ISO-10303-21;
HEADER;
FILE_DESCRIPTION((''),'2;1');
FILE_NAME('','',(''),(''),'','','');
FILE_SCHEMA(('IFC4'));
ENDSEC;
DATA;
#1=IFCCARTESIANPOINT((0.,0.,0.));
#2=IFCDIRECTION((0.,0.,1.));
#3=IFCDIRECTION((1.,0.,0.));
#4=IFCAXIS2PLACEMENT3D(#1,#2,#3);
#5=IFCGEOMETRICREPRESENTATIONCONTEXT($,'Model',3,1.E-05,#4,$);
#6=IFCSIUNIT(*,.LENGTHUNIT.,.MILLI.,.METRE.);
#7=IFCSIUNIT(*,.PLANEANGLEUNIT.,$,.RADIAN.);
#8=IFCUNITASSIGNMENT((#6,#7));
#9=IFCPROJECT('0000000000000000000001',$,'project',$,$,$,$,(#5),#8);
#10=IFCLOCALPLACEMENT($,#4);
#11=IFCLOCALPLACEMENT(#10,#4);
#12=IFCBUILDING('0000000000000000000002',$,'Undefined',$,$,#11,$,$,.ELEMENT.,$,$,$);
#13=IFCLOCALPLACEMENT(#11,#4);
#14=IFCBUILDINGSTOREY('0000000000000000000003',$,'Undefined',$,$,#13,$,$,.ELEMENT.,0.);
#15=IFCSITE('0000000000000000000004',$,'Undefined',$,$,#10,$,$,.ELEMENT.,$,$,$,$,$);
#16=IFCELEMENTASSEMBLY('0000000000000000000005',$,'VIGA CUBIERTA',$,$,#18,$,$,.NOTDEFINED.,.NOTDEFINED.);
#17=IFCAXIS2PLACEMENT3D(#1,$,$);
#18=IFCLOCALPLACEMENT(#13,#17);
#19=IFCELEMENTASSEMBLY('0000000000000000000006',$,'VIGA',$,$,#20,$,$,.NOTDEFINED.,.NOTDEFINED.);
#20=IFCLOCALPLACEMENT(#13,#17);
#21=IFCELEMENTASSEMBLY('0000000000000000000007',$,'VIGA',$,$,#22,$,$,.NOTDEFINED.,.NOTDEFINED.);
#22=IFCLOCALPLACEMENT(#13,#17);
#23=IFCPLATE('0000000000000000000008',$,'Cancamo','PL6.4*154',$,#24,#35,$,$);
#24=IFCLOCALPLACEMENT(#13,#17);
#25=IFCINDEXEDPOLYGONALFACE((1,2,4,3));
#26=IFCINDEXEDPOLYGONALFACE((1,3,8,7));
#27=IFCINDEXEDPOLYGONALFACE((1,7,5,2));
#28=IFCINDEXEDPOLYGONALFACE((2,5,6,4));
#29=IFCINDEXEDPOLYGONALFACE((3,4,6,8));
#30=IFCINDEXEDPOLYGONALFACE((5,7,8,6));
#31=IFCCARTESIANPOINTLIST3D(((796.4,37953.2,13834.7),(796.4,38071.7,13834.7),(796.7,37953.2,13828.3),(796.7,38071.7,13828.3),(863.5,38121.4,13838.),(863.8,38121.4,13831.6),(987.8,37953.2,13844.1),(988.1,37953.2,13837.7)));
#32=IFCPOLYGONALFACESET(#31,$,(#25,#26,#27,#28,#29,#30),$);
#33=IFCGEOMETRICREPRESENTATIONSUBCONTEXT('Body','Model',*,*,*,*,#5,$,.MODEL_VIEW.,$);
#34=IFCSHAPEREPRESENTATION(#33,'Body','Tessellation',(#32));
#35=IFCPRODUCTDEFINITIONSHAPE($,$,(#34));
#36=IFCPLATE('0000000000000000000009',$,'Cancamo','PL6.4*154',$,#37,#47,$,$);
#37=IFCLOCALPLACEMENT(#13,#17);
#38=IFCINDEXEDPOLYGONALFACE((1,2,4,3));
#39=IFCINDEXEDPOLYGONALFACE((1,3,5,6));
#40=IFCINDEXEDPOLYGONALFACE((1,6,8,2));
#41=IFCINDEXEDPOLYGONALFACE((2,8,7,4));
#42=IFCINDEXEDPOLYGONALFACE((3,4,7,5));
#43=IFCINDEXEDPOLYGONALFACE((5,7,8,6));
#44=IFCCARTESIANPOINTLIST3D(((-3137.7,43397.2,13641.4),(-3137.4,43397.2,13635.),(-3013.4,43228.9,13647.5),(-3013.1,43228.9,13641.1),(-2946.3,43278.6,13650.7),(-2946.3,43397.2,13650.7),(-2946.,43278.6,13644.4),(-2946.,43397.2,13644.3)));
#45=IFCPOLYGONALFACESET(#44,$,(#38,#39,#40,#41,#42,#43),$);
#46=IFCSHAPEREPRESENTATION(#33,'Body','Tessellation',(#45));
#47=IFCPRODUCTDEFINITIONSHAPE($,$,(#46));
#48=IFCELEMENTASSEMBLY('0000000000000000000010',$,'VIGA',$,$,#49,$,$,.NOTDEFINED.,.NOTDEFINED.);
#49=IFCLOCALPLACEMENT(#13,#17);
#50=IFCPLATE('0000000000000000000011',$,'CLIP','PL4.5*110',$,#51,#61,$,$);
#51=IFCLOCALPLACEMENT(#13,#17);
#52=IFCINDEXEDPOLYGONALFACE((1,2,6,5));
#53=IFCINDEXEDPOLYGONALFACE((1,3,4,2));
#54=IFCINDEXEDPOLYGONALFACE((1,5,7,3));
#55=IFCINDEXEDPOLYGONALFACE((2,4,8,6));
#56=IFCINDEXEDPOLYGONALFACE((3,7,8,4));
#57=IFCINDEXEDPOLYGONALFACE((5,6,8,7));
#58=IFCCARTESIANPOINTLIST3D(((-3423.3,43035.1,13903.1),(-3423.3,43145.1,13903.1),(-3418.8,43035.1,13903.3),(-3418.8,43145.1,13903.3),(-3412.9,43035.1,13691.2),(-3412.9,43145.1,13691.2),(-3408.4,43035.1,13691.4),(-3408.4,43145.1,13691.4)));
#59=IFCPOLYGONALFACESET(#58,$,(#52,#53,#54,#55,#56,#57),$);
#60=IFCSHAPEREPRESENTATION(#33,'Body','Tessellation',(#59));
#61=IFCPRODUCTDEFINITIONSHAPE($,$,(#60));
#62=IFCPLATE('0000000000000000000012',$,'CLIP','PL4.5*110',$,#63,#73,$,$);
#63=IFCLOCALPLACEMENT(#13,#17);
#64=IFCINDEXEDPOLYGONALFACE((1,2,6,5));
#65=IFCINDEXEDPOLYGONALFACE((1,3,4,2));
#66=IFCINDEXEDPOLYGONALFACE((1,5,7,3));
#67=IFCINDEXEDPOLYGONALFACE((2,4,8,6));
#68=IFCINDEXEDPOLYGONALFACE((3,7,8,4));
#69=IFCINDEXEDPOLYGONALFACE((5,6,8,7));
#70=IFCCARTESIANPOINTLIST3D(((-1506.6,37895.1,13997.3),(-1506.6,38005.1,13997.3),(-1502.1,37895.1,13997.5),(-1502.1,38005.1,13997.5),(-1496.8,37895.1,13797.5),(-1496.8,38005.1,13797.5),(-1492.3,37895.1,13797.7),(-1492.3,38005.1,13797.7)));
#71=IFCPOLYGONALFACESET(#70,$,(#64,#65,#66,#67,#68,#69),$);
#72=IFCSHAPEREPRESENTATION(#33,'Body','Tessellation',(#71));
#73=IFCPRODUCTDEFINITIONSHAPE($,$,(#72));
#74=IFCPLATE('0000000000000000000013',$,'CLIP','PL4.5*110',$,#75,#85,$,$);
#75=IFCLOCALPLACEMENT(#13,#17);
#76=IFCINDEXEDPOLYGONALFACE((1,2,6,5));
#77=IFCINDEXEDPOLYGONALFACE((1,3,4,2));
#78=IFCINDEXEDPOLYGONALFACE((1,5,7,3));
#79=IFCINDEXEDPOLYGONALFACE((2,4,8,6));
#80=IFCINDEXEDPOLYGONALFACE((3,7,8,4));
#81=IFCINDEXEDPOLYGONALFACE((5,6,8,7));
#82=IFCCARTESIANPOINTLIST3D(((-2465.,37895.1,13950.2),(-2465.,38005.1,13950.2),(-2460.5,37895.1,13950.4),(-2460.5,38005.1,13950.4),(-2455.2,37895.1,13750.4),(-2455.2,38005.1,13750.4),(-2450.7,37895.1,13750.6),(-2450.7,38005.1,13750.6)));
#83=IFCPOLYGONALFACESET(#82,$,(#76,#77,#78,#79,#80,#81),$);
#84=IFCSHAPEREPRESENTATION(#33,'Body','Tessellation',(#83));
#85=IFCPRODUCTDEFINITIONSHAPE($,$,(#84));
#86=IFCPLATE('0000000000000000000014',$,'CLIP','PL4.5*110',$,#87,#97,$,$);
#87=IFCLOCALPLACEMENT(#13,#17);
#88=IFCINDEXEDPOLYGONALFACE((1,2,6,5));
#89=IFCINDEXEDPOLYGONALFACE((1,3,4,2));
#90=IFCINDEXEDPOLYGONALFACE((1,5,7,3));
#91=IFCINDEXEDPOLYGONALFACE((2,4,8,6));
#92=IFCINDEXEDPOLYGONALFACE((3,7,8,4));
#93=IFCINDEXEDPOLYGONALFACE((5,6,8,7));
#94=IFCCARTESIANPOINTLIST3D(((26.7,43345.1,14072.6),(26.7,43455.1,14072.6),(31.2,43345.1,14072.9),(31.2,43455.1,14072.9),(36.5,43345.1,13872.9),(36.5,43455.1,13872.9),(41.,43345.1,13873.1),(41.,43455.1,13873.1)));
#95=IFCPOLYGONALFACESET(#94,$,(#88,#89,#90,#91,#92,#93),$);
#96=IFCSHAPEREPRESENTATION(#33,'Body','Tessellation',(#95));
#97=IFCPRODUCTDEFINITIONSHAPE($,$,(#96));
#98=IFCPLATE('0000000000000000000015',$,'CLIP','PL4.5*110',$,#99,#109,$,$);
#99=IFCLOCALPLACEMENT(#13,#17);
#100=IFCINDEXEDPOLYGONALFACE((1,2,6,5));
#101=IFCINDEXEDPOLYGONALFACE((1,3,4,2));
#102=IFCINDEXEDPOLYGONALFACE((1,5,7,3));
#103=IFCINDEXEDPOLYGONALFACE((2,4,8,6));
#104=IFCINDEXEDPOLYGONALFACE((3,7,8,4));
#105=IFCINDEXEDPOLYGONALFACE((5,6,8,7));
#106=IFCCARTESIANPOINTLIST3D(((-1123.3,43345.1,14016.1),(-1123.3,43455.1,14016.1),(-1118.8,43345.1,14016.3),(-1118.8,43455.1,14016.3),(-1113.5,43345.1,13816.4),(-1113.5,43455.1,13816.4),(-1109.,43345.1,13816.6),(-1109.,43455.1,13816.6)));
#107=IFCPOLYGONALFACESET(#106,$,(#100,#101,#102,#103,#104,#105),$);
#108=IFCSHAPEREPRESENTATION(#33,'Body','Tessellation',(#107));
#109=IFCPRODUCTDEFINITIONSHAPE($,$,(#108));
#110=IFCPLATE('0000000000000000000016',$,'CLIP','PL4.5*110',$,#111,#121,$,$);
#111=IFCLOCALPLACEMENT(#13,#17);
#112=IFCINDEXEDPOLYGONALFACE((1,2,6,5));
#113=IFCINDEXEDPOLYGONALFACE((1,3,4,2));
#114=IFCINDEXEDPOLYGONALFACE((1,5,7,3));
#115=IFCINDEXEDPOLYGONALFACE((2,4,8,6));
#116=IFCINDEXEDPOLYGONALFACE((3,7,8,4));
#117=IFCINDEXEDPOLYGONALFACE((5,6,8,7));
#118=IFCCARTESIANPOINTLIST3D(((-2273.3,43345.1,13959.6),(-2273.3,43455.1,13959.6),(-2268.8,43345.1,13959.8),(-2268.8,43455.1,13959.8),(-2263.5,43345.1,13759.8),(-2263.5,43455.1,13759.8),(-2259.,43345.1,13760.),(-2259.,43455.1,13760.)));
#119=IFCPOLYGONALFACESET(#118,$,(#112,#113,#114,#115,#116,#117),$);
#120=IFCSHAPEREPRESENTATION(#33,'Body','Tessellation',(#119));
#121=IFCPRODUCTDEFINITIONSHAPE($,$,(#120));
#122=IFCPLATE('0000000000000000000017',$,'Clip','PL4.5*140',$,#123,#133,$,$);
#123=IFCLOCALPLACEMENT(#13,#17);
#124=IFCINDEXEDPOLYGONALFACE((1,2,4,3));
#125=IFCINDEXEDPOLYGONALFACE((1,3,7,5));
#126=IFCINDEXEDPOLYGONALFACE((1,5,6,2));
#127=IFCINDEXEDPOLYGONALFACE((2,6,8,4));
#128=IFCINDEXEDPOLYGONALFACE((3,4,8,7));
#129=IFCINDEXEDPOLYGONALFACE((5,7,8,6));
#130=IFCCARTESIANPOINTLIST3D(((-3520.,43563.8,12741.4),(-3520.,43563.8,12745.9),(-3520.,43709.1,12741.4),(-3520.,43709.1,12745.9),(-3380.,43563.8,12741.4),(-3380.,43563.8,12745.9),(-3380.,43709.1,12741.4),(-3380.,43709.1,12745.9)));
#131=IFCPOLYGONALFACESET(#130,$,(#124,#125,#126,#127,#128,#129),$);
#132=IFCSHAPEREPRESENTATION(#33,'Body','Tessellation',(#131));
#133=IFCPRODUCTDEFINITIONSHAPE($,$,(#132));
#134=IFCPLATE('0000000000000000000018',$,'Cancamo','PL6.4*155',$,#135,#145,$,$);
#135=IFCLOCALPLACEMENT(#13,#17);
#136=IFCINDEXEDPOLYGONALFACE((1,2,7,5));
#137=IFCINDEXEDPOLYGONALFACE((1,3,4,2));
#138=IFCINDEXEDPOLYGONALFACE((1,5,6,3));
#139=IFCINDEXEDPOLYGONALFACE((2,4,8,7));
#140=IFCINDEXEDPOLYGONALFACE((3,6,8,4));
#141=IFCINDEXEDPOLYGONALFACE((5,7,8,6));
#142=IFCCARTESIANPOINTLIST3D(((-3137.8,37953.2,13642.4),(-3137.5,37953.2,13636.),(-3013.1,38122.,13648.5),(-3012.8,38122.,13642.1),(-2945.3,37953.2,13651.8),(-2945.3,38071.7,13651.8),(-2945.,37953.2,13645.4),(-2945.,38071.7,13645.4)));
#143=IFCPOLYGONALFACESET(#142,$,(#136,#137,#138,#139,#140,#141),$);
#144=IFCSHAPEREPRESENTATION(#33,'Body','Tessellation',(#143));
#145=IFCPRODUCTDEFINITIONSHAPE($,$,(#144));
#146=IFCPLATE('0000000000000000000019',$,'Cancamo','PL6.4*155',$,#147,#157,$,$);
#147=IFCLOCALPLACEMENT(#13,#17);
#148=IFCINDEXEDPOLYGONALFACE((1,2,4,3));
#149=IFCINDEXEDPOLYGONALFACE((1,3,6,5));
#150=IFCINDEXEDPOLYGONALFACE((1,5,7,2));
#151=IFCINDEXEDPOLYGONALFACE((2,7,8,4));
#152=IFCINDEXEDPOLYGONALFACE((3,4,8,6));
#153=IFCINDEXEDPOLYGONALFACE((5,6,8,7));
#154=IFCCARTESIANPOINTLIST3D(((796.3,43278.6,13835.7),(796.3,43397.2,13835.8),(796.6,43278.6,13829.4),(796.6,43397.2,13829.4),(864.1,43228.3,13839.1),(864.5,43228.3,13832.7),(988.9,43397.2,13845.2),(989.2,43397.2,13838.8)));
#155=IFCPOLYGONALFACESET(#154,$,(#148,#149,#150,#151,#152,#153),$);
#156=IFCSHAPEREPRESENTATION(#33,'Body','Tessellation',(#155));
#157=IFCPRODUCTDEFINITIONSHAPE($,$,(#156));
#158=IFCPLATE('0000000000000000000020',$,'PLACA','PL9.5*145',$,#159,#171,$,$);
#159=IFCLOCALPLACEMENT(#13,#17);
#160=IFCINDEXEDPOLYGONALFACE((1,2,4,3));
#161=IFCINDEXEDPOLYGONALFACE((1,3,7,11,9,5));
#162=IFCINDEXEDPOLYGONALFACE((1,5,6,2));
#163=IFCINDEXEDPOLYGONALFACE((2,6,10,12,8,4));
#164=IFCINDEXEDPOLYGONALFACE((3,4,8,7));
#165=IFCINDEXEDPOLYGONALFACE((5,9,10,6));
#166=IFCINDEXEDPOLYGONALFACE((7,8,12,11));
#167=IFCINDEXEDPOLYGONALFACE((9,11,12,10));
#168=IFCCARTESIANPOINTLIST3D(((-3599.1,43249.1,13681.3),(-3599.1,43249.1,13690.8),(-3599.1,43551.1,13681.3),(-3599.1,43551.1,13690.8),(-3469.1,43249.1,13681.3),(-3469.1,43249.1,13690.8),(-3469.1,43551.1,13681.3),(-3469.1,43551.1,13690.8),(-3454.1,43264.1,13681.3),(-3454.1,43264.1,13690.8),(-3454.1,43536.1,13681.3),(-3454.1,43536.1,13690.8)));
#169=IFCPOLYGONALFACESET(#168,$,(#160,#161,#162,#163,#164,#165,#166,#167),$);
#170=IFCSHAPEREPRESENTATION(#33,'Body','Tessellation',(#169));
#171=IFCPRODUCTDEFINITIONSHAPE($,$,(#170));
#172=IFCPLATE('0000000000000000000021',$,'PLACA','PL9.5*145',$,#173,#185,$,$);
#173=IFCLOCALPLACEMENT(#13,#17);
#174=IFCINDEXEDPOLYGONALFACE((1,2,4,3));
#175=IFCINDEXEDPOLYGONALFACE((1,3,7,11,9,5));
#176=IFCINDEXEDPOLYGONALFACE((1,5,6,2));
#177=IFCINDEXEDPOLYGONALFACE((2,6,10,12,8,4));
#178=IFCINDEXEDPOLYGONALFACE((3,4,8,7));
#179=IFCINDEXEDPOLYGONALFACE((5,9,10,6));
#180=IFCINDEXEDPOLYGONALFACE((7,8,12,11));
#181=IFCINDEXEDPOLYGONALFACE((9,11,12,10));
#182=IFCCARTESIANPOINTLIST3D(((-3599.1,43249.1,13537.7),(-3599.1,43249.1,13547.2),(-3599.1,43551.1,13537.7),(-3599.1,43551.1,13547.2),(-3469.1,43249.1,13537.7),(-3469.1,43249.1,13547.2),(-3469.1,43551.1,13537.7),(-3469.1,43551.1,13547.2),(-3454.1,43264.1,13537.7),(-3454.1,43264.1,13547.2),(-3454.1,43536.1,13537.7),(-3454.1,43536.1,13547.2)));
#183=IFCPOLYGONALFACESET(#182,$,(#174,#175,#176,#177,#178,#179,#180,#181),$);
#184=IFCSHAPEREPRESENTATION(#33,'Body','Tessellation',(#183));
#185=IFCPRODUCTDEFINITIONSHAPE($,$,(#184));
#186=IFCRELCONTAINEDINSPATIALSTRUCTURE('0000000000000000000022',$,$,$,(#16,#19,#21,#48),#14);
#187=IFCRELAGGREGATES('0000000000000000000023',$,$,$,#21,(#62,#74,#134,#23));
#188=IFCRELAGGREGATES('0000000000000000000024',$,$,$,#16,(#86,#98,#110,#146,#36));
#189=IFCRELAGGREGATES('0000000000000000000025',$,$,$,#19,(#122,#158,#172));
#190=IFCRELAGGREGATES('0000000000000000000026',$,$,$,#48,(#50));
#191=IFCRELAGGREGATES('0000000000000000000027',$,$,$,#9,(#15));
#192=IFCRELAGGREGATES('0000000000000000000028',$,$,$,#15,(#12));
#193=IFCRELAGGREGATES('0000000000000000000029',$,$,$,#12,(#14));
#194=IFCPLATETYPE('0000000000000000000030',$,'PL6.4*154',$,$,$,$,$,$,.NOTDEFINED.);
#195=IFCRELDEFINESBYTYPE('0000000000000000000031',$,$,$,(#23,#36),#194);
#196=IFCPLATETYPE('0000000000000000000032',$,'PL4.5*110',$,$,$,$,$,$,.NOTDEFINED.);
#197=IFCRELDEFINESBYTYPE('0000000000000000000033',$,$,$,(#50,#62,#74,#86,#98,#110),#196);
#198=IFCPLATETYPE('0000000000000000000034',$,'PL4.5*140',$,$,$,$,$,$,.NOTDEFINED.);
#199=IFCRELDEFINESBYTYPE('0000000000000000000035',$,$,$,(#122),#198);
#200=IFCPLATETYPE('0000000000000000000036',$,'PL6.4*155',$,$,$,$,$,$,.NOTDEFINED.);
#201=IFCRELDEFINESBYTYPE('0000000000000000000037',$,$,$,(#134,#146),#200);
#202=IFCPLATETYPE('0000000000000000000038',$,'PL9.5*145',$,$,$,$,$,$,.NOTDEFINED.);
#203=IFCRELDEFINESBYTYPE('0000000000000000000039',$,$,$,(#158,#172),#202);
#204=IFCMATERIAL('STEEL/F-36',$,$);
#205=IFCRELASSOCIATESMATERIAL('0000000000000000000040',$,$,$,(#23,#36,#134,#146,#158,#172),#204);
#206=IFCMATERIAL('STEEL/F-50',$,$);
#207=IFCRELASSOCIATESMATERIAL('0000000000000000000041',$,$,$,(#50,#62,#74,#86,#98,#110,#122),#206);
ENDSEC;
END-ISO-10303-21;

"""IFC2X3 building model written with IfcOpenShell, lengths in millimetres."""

from ifc_helpers import new_model, si_unit, frame, origin_with_axes, place, context, subcontext, project, spatial, polyline, outline, extrude, material, type_object, element, aggregate, save


model = new_model("IFC2X3")

# Units and contexts
model_context = context("Model", 3, precision=1e-05, world=origin_with_axes())
body_context = subcontext(model_context, "Body", "Model", "MODEL_VIEW")
ifc_project = project(units=[si_unit("LENGTHUNIT", "METRE", prefix="MILLI"), si_unit("PLANEANGLEUNIT", "RADIAN")], contexts=[model_context])

# Site, building, storey
site_placement = place(None, origin_with_axes())
site = spatial("IfcSite", under=ifc_project, at=site_placement, Name="Undefined", CompositionType="ELEMENT")
building_placement = place(site_placement, origin_with_axes())
building = spatial("IfcBuilding", under=site, at=building_placement, Name="Undefined", CompositionType="ELEMENT")
storey_placement = place(building_placement, origin_with_axes())
storey = spatial("IfcBuildingStorey", under=building, at=storey_placement, Name="Undefined", CompositionType="ELEMENT", Elevation=0.0)

# Element assembly
assembly_1_placement = place(storey_placement, origin_with_axes())
assembly_1 = element("IfcElementAssembly", 1, at=assembly_1_placement, inside=storey, Name="VIGA CUBIERTA", AssemblyPlace="NOTDEFINED", PredefinedType="NOTDEFINED")
ifc_material_1 = material(Name="STEEL/F-36")

# Element assembly
assembly_2_placement = place(storey_placement, origin_with_axes())
assembly_2 = element("IfcElementAssembly", 2, at=assembly_2_placement, inside=storey, Name="VIGA", AssemblyPlace="NOTDEFINED", PredefinedType="NOTDEFINED")
ifc_material_2 = material(Name="STEEL/F-50")

# Element assembly, plate
assembly_3_placement = place(storey_placement, origin_with_axes())
assembly_3 = element("IfcElementAssembly", 3, at=assembly_3_placement, inside=storey, Name="VIGA", AssemblyPlace="NOTDEFINED", PredefinedType="NOTDEFINED")
plate_type_1 = type_object("IfcPlateType", Name="PL6.4*154", PredefinedType="NOTDEFINED")
plate_1_placement = place(assembly_3_placement, frame((796.6, 37953.2, 13831.5), z_axis=(-0.04909, 0.0, 0.998794), x_axis=(0.998794, 0.0, 0.04909)))
plate_1 = element("IfcPlate", 4, at=plate_1_placement, type_object=plate_type_1, material=ifc_material_1, Name="Cancamo", Description="PL6.4*154", context=body_context, shape_type="SweptSolid", body=[
    extrude(outline(polyline([(0.0, 0.0), (191.6, 0.0), (67.2, 168.3), (0.0, 118.6), (0.0, 0.0)])), frame((0.0, 0.0, -3.2), z_axis=(0.0, 0.0, 1.0), x_axis=(1.0, 0.0, 0.0)), (0.0, 0.0, 1.0), 6.4),
])

# Plate
plate_2_placement = place(assembly_1_placement, frame((-2946.2, 43397.2, 13647.5), z_axis=(-0.048847, 0.00018, 0.998806), x_axis=(-0.998806, 0.0, -0.048847)))
plate_2 = element("IfcPlate", 5, at=plate_2_placement, type_object=plate_type_1, material=ifc_material_1, Name="Cancamo", Description="PL6.4*154", context=body_context, shape_type="SweptSolid", body=[
    extrude(outline(polyline([(0.0, 0.0), (191.6, 0.0), (67.2, 168.3), (0.0, 118.6), (0.0, 0.0)])), frame((0.0, 0.0, -3.2), z_axis=(0.0, 0.0, 1.0), x_axis=(1.0, 0.0, 0.0)), (0.0, 0.0, 1.0), 6.4),
])

# Element assembly, plate
assembly_4_placement = place(storey_placement, origin_with_axes())
assembly_4 = element("IfcElementAssembly", 6, at=assembly_4_placement, inside=storey, Name="VIGA", AssemblyPlace="NOTDEFINED", PredefinedType="NOTDEFINED")
plate_type_2 = type_object("IfcPlateType", Name="PL4.5*110", PredefinedType="NOTDEFINED")
plate_3_placement = place(assembly_4_placement, frame((-3410.7, 43145.1, 13691.3), z_axis=(-0.998794, 0.0, -0.04909), x_axis=(0.0, -1.0, 0.0)))
plate_3 = element("IfcPlate", 7, at=plate_3_placement, type_object=plate_type_2, material=ifc_material_2, Name="CLIP", Description="PL4.5*110", context=body_context, shape_type="SweptSolid", body=[
    extrude(outline(polyline([(0.0, 0.0), (110.0, 0.0), (110.0, 212.2), (0.0, 212.2), (0.0, 0.0)])), frame((0.0, 0.0, -2.2), z_axis=(0.0, 0.0, 1.0), x_axis=(1.0, 0.0, 0.0)), (0.0, 0.0, 1.0), 4.5),
])

# Plates
plate_4_placement = place(assembly_3_placement, frame((-1494.6, 38005.1, 13797.6), z_axis=(-0.998794, 0.0, -0.04909), x_axis=(0.0, -1.0, 0.0)))
plate_4 = element("IfcPlate", 8, at=plate_4_placement, type_object=plate_type_2, material=ifc_material_2, Name="CLIP", Description="PL4.5*110", context=body_context, shape_type="SweptSolid", body=[
    extrude(outline(polyline([(0.0, 0.0), (110.0, 0.0), (110.0, 200.0), (0.0, 200.0), (0.0, 0.0)])), frame((0.0, 0.0, -2.2), z_axis=(0.0, 0.0, 1.0), x_axis=(1.0, 0.0, 0.0)), (0.0, 0.0, 1.0), 4.5),
])
plate_5_placement = place(assembly_3_placement, frame((-2452.9, 38005.1, 13750.5), z_axis=(-0.998794, 0.0, -0.04909), x_axis=(0.0, -1.0, 0.0)))
plate_5 = element("IfcPlate", 9, at=plate_5_placement, type_object=plate_type_2, material=ifc_material_2, Name="CLIP", Description="PL4.5*110", context=body_context, shape_type="SweptSolid", body=[
    extrude(outline(polyline([(0.0, 0.0), (110.0, 0.0), (110.0, 200.0), (0.0, 200.0), (0.0, 0.0)])), frame((0.0, 0.0, -2.2), z_axis=(0.0, 0.0, 1.0), x_axis=(1.0, 0.0, 0.0)), (0.0, 0.0, 1.0), 4.5),
])
plate_6_placement = place(assembly_1_placement, frame((38.8, 43455.1, 13873.0), z_axis=(-0.998794, 0.0, -0.04909), x_axis=(0.0, -1.0, 0.0)))
plate_6 = element("IfcPlate", 10, at=plate_6_placement, type_object=plate_type_2, material=ifc_material_2, Name="CLIP", Description="PL4.5*110", context=body_context, shape_type="SweptSolid", body=[
    extrude(outline(polyline([(0.0, 0.0), (110.0, 0.0), (110.0, 200.0), (0.0, 200.0), (0.0, 0.0)])), frame((0.0, 0.0, -2.2), z_axis=(0.0, 0.0, 1.0), x_axis=(1.0, 0.0, 0.0)), (0.0, 0.0, 1.0), 4.5),
])
plate_7_placement = place(assembly_1_placement, frame((-1111.2, 43455.1, 13816.5), z_axis=(-0.998794, 0.0, -0.04909), x_axis=(0.0, -1.0, 0.0)))
plate_7 = element("IfcPlate", 11, at=plate_7_placement, type_object=plate_type_2, material=ifc_material_2, Name="CLIP", Description="PL4.5*110", context=body_context, shape_type="SweptSolid", body=[
    extrude(outline(polyline([(0.0, 0.0), (110.0, 0.0), (110.0, 200.0), (0.0, 200.0), (0.0, 0.0)])), frame((0.0, 0.0, -2.2), z_axis=(0.0, 0.0, 1.0), x_axis=(1.0, 0.0, 0.0)), (0.0, 0.0, 1.0), 4.5),
])
plate_8_placement = place(assembly_1_placement, frame((-2261.2, 43455.1, 13759.9), z_axis=(-0.998794, 0.0, -0.04909), x_axis=(0.0, -1.0, 0.0)))
plate_8 = element("IfcPlate", 12, at=plate_8_placement, type_object=plate_type_2, material=ifc_material_2, Name="CLIP", Description="PL4.5*110", context=body_context, shape_type="SweptSolid", body=[
    extrude(outline(polyline([(0.0, 0.0), (110.0, 0.0), (110.0, 200.0), (0.0, 200.0), (0.0, 0.0)])), frame((0.0, 0.0, -2.2), z_axis=(0.0, 0.0, 1.0), x_axis=(1.0, 0.0, 0.0)), (0.0, 0.0, 1.0), 4.5),
])
plate_type_3 = type_object("IfcPlateType", Name="PL4.5*140", PredefinedType="NOTDEFINED")
plate_9_placement = place(assembly_2_placement, frame((-3380.0, 43563.8, 12743.7), z_axis=(0.0, 0.0, 1.0), x_axis=(0.000002, 1.0, 0.0)))
plate_9 = element("IfcPlate", 13, at=plate_9_placement, type_object=plate_type_3, material=ifc_material_2, Name="Clip", Description="PL4.5*140", context=body_context, shape_type="SweptSolid", body=[
    extrude(outline(polyline([(0.0, 0.0), (145.3, 0.0), (145.3, 140.0), (0.0, 140.0), (0.0, 0.0)])), frame((0.0, 0.0, -2.2), z_axis=(0.0, 0.0, 1.0), x_axis=(1.0, 0.0, 0.0)), (0.0, 0.0, 1.0), 4.5),
])
plate_type_4 = type_object("IfcPlateType", Name="PL6.4*155", PredefinedType="NOTDEFINED")
plate_10_placement = place(assembly_3_placement, frame((-2945.1, 37953.2, 13648.6), z_axis=(0.04909, 0.0, -0.998794), x_axis=(-0.998794, 0.0, -0.04909)))
plate_10 = element("IfcPlate", 14, at=plate_10_placement, type_object=plate_type_4, material=ifc_material_1, Name="Cancamo", Description="PL6.4*155", context=body_context, shape_type="SweptSolid", body=[
    extrude(outline(polyline([(0.0, 0.0), (192.8, 0.0), (67.9, 168.8), (0.0, 118.6), (0.0, 0.0)])), frame((0.0, 0.0, -3.2), z_axis=(0.0, 0.0, 1.0), x_axis=(1.0, 0.0, 0.0)), (0.0, 0.0, 1.0), 6.4),
])
aggregate(assembly_3, [plate_4, plate_5, plate_10, plate_1])
plate_11_placement = place(assembly_1_placement, frame((796.4, 43397.2, 13832.6), z_axis=(0.048847, 0.00018, -0.998806), x_axis=(0.998806, 0.0, 0.048847)))
plate_11 = element("IfcPlate", 15, at=plate_11_placement, type_object=plate_type_4, material=ifc_material_1, Name="Cancamo", Description="PL6.4*155", context=body_context, shape_type="SweptSolid", body=[
    extrude(outline(polyline([(0.0, 0.0), (192.8, 0.0), (67.9, 168.8), (0.0, 118.6), (0.0, 0.0)])), frame((0.0, 0.0, -3.2), z_axis=(0.0, 0.0, 1.0), x_axis=(1.0, 0.0, 0.0)), (0.0, 0.0, 1.0), 6.4),
])
aggregate(assembly_1, [plate_6, plate_7, plate_8, plate_11, plate_2])
plate_type_5 = type_object("IfcPlateType", Name="PL9.5*145", PredefinedType="NOTDEFINED")
plate_12_placement = place(assembly_2_placement, frame((-3454.1, 43249.1, 13686.1), z_axis=(0.000002, -0.000009, -1.0), x_axis=(-1.0, 0.0, -0.000002)))
plate_12 = element("IfcPlate", 16, at=plate_12_placement, type_object=plate_type_5, material=ifc_material_1, Name="PLACA", Description="PL9.5*145", context=body_context, shape_type="SweptSolid", body=[
    extrude(outline(polyline([(0.0, 15.0), (15.0, 0.0), (145.0, 0.0), (145.0, 301.9), (15.0, 301.9), (0.0, 286.9), (0.0, 15.0)])), frame((0.0, 0.0, -4.8), z_axis=(0.0, 0.0, 1.0), x_axis=(1.0, 0.0, 0.0)), (0.0, 0.0, 1.0), 9.5),
])
plate_13_placement = place(assembly_2_placement, frame((-3454.1, 43249.1, 13542.5), z_axis=(0.000002, -0.000009, -1.0), x_axis=(-1.0, 0.0, -0.000002)))
plate_13 = element("IfcPlate", 17, at=plate_13_placement, type_object=plate_type_5, material=ifc_material_1, Name="PLACA", Description="PL9.5*145", context=body_context, shape_type="SweptSolid", body=[
    extrude(outline(polyline([(0.0, 15.0), (15.0, 0.0), (145.0, 0.0), (145.0, 301.9), (15.0, 301.9), (0.0, 286.9), (0.0, 15.0)])), frame((0.0, 0.0, -4.8), z_axis=(0.0, 0.0, 1.0), x_axis=(1.0, 0.0, 0.0)), (0.0, 0.0, 1.0), 9.5),
])

aggregate(assembly_2, [plate_9, plate_12, plate_13])
aggregate(assembly_4, [plate_3])

save(model, "model.ifc")
